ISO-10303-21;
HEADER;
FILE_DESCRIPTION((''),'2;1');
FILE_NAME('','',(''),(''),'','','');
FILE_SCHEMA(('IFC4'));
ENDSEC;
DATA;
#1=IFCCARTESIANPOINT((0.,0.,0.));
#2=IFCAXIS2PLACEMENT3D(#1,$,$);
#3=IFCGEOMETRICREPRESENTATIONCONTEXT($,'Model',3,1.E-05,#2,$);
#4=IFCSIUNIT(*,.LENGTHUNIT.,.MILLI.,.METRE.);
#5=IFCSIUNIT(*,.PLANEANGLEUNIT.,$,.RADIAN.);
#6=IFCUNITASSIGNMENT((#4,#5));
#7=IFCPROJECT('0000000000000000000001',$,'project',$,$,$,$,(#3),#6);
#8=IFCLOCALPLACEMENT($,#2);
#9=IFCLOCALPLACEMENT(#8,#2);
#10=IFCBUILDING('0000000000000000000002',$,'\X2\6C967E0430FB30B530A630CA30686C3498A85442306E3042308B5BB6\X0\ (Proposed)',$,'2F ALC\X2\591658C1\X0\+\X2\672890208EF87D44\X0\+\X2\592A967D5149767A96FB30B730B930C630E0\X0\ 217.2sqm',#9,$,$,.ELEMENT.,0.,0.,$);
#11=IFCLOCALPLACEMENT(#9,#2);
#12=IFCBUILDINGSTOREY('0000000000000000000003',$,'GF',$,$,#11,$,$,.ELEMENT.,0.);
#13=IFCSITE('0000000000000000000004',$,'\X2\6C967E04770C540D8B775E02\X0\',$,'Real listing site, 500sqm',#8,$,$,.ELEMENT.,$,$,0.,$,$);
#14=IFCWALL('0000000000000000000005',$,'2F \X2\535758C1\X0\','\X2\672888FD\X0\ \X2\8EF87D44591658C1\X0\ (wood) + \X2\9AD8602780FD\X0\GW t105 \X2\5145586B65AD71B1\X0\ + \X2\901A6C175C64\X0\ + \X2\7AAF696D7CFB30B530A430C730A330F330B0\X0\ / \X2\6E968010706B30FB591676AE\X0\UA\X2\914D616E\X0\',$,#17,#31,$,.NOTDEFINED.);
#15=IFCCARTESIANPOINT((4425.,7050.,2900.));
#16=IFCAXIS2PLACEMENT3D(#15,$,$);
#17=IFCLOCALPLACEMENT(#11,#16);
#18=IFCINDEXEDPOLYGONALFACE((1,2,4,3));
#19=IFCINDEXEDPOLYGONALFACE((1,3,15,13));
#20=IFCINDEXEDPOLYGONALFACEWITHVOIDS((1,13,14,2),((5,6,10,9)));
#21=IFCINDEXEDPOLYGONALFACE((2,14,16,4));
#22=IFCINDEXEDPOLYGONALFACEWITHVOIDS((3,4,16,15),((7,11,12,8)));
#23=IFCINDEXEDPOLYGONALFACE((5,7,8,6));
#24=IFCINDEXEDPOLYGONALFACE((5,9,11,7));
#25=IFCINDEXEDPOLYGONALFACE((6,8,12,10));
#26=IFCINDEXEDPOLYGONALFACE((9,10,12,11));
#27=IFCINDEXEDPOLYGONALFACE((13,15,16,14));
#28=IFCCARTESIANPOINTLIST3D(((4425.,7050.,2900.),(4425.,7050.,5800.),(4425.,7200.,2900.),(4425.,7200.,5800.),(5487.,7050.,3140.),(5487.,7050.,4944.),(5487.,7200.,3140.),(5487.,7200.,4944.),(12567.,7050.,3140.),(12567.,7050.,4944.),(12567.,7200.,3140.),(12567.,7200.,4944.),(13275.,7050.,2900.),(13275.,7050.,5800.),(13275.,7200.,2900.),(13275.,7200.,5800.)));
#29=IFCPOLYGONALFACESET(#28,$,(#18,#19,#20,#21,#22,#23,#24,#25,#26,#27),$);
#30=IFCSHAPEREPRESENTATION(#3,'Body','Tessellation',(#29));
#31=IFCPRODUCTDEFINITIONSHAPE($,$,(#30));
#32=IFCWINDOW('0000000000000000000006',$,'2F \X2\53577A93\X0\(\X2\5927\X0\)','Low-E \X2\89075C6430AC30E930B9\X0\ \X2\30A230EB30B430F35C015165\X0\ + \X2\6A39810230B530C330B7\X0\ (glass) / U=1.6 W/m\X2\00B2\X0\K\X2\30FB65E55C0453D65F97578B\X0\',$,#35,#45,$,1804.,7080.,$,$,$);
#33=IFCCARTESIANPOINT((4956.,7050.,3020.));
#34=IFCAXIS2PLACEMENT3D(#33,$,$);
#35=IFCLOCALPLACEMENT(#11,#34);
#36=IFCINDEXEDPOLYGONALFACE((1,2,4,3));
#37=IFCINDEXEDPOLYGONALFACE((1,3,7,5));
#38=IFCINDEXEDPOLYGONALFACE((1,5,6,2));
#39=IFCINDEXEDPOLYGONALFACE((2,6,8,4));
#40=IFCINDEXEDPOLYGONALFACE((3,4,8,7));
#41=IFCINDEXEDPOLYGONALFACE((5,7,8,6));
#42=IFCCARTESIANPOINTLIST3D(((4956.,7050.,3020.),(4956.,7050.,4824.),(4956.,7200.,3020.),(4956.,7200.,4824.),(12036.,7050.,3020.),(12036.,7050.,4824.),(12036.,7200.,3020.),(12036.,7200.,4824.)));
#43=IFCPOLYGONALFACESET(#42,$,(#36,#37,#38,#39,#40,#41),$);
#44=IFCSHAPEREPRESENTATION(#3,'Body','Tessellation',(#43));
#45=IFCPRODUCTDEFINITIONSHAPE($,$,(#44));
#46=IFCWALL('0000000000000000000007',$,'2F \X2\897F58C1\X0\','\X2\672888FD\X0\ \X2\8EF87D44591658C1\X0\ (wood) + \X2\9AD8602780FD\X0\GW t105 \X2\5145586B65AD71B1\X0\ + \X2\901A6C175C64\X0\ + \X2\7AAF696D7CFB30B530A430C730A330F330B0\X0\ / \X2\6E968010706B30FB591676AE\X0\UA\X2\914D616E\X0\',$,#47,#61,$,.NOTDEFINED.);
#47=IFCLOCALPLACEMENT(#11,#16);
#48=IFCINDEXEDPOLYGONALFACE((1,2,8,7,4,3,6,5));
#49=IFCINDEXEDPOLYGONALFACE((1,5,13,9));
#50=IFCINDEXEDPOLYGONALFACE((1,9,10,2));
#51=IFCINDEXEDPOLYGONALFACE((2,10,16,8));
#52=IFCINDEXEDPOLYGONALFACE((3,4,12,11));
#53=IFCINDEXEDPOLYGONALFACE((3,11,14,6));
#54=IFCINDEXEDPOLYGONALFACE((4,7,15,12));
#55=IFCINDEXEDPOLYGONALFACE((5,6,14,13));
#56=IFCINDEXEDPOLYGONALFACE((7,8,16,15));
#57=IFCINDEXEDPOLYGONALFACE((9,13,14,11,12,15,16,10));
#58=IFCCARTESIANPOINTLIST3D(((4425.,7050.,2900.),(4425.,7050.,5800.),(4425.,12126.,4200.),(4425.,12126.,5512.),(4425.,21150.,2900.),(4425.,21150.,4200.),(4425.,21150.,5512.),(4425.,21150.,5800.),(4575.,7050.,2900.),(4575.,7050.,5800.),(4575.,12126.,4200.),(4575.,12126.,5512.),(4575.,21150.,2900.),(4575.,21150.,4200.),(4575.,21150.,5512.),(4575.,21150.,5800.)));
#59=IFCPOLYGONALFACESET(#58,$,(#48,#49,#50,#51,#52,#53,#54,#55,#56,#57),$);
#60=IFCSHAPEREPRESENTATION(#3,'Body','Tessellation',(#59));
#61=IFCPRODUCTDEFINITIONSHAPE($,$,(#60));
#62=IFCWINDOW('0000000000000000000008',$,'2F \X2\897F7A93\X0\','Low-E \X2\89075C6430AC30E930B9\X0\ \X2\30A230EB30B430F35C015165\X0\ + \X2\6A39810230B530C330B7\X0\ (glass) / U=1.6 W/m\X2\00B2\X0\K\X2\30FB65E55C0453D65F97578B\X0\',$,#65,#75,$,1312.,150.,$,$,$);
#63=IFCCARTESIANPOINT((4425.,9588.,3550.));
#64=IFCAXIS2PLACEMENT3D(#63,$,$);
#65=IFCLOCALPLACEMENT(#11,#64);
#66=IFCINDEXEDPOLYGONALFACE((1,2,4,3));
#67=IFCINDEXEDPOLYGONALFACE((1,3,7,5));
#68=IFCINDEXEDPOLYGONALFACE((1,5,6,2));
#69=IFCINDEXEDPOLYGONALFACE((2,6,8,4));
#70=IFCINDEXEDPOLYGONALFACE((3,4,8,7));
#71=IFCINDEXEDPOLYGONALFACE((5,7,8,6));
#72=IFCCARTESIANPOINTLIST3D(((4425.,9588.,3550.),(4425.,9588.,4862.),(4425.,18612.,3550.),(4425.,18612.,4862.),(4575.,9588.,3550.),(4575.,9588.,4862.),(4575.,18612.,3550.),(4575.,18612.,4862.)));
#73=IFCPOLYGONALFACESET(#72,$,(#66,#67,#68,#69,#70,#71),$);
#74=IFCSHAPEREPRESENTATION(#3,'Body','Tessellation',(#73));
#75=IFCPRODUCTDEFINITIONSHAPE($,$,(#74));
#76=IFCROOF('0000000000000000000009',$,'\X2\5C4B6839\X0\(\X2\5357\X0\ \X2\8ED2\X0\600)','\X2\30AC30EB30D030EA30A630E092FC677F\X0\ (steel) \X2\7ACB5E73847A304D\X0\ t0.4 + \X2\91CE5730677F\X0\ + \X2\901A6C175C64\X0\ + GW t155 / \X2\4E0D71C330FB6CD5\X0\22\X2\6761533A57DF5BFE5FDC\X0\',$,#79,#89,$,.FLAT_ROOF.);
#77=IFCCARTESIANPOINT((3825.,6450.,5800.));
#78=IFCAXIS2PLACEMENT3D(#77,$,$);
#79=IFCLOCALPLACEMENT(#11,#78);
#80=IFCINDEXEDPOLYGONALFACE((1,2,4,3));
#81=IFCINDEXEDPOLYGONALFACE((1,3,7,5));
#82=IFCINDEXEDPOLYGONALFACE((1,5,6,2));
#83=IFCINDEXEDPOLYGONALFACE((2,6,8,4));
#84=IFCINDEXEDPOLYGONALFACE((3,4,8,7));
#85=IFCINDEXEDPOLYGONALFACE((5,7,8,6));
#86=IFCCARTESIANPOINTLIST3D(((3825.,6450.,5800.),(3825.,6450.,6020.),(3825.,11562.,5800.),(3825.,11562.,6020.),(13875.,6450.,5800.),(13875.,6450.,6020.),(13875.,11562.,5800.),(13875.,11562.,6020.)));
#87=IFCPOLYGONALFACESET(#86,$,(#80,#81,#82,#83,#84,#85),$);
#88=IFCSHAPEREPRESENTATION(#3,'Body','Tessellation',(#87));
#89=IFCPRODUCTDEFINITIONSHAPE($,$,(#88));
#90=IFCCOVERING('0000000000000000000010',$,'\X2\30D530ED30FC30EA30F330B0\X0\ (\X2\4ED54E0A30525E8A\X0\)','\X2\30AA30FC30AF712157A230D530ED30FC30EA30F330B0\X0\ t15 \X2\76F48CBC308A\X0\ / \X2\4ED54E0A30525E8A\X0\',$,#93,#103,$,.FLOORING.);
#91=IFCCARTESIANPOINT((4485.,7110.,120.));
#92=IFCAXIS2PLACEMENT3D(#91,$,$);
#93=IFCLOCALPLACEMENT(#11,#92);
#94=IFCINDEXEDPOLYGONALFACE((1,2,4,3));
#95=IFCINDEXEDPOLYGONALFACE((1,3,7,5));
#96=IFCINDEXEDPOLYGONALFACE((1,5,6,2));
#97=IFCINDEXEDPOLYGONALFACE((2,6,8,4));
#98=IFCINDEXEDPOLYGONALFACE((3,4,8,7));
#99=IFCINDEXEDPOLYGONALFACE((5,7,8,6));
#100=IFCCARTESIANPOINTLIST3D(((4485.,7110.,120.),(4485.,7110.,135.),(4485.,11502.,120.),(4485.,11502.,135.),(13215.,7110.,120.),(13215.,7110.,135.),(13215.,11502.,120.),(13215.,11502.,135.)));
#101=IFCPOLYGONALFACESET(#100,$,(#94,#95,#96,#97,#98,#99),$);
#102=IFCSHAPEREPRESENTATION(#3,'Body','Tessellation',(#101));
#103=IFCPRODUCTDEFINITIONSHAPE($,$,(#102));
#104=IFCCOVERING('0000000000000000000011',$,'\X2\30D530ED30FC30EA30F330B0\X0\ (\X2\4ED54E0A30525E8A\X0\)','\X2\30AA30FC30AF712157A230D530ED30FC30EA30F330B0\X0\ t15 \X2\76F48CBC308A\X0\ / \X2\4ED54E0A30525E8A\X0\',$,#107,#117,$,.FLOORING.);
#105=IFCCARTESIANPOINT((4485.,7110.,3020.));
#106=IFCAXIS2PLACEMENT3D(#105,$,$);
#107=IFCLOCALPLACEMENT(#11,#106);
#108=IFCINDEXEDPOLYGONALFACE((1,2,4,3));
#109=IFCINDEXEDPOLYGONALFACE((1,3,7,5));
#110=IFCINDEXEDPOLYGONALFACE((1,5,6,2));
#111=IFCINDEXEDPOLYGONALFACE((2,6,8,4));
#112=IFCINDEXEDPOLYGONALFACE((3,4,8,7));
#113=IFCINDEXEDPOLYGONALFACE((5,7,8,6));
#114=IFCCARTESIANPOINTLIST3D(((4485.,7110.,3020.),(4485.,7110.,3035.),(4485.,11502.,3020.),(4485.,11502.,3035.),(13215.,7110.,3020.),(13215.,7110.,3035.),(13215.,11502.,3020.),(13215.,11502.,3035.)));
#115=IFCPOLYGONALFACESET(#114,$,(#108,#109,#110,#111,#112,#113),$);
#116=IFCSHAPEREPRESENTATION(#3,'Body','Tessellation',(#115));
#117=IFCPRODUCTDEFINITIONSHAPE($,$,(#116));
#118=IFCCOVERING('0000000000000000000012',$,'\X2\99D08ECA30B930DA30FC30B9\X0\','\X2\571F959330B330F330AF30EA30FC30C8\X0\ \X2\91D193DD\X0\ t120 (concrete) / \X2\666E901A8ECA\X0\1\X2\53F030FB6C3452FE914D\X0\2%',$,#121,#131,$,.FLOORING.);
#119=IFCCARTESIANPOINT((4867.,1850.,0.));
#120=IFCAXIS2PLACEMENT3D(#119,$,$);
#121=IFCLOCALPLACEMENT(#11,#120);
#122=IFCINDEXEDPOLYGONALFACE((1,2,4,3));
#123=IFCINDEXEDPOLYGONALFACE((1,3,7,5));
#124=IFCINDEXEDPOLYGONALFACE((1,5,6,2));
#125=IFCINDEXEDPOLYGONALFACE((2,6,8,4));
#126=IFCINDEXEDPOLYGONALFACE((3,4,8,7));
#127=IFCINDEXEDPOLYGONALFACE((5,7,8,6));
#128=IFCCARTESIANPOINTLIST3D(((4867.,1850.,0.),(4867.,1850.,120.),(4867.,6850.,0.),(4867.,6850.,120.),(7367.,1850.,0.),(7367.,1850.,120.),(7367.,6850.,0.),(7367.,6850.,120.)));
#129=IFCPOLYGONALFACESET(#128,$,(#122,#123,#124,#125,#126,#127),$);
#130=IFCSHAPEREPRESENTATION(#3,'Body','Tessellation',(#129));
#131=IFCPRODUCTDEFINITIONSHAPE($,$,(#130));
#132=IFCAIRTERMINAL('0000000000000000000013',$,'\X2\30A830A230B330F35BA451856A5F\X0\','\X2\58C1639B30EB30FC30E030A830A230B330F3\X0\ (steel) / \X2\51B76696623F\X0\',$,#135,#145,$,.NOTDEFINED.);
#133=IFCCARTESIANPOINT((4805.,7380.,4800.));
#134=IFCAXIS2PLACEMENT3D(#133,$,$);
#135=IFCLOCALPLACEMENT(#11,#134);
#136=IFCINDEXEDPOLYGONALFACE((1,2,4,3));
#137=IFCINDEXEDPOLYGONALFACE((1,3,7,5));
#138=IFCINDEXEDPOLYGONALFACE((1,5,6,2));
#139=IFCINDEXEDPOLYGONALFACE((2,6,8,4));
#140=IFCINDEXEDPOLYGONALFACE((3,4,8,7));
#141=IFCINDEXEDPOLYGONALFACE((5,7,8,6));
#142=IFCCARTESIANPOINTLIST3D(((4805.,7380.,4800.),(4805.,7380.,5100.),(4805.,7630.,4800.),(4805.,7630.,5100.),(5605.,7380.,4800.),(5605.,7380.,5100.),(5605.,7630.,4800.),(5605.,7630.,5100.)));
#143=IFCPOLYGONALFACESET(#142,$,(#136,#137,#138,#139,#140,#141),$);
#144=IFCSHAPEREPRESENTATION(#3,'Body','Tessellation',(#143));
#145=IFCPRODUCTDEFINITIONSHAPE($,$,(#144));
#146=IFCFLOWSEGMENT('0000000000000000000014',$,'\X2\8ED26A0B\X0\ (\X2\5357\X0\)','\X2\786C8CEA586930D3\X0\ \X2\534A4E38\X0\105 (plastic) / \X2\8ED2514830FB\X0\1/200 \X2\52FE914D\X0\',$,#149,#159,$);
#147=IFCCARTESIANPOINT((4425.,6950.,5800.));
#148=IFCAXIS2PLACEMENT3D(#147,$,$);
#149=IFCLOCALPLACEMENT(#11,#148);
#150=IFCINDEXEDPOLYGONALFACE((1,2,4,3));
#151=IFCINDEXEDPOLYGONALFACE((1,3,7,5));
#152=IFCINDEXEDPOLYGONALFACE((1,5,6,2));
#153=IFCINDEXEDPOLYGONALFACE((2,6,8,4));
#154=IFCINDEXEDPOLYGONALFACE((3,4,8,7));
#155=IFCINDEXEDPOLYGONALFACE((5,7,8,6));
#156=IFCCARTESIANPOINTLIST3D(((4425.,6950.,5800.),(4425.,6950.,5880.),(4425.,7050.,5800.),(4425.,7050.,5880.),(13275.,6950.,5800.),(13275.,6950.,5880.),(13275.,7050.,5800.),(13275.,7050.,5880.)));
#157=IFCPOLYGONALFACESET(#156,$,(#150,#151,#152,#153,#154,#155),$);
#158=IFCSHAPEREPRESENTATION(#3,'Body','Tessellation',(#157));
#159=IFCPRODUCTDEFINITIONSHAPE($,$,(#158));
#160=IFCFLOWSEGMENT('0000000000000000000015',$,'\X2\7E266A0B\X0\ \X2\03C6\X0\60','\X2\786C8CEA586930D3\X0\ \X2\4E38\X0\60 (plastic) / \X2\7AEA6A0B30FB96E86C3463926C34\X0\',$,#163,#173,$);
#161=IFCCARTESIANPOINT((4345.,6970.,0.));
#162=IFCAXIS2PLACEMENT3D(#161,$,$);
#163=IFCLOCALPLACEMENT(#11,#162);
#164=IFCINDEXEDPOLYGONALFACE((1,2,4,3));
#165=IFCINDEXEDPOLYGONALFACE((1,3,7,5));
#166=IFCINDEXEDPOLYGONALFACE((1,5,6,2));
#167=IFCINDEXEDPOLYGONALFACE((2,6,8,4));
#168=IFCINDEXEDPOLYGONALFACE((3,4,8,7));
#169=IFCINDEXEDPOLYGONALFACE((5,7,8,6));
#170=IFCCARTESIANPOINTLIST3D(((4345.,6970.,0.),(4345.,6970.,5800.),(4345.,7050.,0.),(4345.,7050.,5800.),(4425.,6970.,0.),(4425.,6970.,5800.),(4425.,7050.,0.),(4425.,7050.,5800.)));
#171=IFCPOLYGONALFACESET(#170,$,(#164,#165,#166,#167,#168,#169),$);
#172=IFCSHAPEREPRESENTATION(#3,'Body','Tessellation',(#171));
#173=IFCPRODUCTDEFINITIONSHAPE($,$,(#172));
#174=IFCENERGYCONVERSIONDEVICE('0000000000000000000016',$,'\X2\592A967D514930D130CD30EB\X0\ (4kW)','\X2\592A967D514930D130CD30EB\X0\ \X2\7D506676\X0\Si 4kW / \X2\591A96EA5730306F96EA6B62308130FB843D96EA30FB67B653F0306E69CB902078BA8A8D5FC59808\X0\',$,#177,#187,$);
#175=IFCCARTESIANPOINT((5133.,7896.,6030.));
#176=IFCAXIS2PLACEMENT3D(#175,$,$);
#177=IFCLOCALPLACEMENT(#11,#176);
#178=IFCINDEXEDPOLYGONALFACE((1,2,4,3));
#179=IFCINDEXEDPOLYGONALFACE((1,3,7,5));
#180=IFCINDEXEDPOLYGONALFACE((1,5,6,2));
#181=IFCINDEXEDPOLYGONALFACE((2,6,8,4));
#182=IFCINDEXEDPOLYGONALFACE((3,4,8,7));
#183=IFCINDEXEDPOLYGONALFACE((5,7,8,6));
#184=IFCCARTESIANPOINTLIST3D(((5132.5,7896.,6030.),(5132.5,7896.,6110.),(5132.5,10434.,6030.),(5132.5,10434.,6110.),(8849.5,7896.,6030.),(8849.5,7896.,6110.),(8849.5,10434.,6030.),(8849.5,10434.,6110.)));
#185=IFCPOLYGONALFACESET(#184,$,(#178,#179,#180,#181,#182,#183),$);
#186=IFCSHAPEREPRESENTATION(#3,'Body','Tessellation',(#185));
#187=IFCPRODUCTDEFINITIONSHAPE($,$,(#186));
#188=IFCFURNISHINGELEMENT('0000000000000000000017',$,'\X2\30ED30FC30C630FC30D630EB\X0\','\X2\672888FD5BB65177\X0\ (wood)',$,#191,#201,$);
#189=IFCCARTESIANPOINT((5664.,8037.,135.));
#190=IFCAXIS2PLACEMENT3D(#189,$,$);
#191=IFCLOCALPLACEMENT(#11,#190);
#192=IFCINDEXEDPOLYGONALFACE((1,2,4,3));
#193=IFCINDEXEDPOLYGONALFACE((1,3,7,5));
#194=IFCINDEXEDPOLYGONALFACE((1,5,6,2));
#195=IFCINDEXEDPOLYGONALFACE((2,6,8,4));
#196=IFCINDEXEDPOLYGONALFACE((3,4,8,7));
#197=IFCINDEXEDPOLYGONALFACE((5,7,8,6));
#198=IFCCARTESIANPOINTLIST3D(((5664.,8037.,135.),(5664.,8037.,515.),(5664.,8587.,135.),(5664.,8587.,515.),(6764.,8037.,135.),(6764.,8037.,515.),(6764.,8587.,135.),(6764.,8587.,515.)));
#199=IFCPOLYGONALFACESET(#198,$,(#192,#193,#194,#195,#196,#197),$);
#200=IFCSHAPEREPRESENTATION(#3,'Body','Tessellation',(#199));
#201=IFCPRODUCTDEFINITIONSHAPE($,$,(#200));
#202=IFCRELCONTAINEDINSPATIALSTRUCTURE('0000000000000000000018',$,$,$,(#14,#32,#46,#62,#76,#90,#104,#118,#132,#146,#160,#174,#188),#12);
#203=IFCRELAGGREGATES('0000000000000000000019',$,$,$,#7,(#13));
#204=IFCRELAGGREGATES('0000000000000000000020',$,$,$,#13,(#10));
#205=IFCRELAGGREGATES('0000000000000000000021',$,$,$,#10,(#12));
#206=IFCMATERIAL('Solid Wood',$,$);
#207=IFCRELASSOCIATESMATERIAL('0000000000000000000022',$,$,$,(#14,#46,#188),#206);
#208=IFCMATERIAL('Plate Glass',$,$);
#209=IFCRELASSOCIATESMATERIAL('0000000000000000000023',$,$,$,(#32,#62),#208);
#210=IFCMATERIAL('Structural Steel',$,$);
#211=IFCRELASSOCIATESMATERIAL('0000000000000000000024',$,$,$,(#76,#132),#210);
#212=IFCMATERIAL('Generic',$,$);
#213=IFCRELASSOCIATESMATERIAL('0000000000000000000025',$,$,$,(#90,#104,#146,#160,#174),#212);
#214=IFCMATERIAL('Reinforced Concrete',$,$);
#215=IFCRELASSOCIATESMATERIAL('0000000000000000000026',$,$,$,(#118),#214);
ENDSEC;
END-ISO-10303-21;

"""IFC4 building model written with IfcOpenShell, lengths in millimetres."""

from ifc_helpers import new_model, si_unit, frame, frame_2d, origin, place, context, project, spatial, rectangle, extrude, material, element, fill, save


model = new_model("IFC4")

# Units and contexts
model_context = context("Model", 3, precision=1e-05, world=origin())
ifc_project = project(units=[si_unit("LENGTHUNIT", "METRE", prefix="MILLI"), si_unit("PLANEANGLEUNIT", "RADIAN")], contexts=[model_context])

# Site, building, storey
site_placement = place(None, origin())
site = spatial("IfcSite", under=ifc_project, at=site_placement, Name="沖縄県名護市", ObjectType="Real listing site, 500sqm", CompositionType="ELEMENT", RefElevation=0.0)
building_placement = place(site_placement, origin())
building = spatial("IfcBuilding", under=site, at=building_placement, Name="沖縄・サウナと水風呂のある家 (Proposed)", ObjectType="2F ALC外壁+木造軸組+太陽光発電システム 217.2sqm", CompositionType="ELEMENT", ElevationOfRefHeight=0.0, ElevationOfTerrain=0.0)
storey_placement = place(building_placement, origin())
storey = spatial("IfcBuildingStorey", under=building, at=storey_placement, Name="GF", CompositionType="ELEMENT", Elevation=0.0)

# Shared definitions
ifc_material_1 = material(Name="Solid Wood")

# Shared definitions
ifc_material_2 = material(Name="Reinforced Concrete")

# Shared definitions
ifc_material_3 = material(Name="Plate Glass")

# Walls, openings, windows
wall_1_placement = place(storey_placement, frame((4425.0, 7050.0, 2900.0)))
wall_1 = element("IfcWall", 1, at=wall_1_placement, inside=storey, material=ifc_material_1, Name="2F 南壁", Description="木製 軸組外壁 (wood) + 高性能GW t105 充填断熱 + 通気層 + 窯業系サイディング / 準耐火・外皮UA配慮", PredefinedType="NOTDEFINED", context=model_context, shape_type="SweptSolid", body=[
    extrude(rectangle(XDim=8850.0, YDim=150.0, at=frame_2d((4425.0, 75.0))), frame((4425.0, 7050.0, 2900.0)), (0.0, 0.0, 1.0), 2900.0),
])
opening_1_placement = place(storey_placement, frame((4956.0, 7050.0, 3020.0)))
opening_1 = element("IfcOpeningElement", 2, at=opening_1_placement, cuts=wall_1, PredefinedType="NOTDEFINED", context=model_context, shape_type="SweptSolid", body=[
    extrude(rectangle(XDim=7080.0, YDim=150.0, at=frame_2d((3540.0, 75.0))), frame((4956.0, 7050.0, 3020.0)), (0.0, 0.0, 1.0), 1804.0),
])
window_1_placement = place(storey_placement, frame((4956.0, 7050.0, 3020.0)))
window_1 = element("IfcWindow", 3, at=window_1_placement, inside=storey, material=ifc_material_3, Name="2F 南窓(大)", Description="Low-E 複層ガラス アルゴン封入 + 樹脂サッシ (glass) / U=1.6 W/m²K・日射取得型", OverallHeight=1804.0, OverallWidth=7080.0, context=model_context, shape_type="SweptSolid", body=[
    extrude(rectangle(XDim=7080.0, YDim=150.0, at=frame_2d((3540.0, 75.0))), frame((4956.0, 7050.0, 3020.0)), (0.0, 0.0, 1.0), 1804.0),
])
fill(opening_1, window_1)
wall_2_placement = place(storey_placement, frame((4425.0, 7050.0, 2900.0)))
wall_2 = element("IfcWall", 4, at=wall_2_placement, inside=storey, material=ifc_material_1, Name="2F 西壁", Description="木製 軸組外壁 (wood) + 高性能GW t105 充填断熱 + 通気層 + 窯業系サイディング / 準耐火・外皮UA配慮", PredefinedType="NOTDEFINED", context=model_context, shape_type="SweptSolid", body=[
    extrude(rectangle(XDim=150.0, YDim=14100.0, at=frame_2d((75.0, 7050.0))), frame((4425.0, 7050.0, 2900.0)), (0.0, 0.0, 1.0), 2900.0),
])
opening_2_placement = place(storey_placement, frame((4425.0, 9588.0, 3550.0)))
opening_2 = element("IfcOpeningElement", 5, at=opening_2_placement, cuts=wall_2, PredefinedType="NOTDEFINED", context=model_context, shape_type="SweptSolid", body=[
    extrude(rectangle(XDim=150.0, YDim=9024.0, at=frame_2d((75.0, 4512.0))), frame((4425.0, 9588.0, 3550.0)), (0.0, 0.0, 1.0), 1312.0),
])
window_2_placement = place(storey_placement, frame((4425.0, 9588.0, 3550.0)))
window_2 = element("IfcWindow", 6, at=window_2_placement, inside=storey, material=ifc_material_3, Name="2F 西窓", Description="Low-E 複層ガラス アルゴン封入 + 樹脂サッシ (glass) / U=1.6 W/m²K・日射取得型", OverallHeight=1312.0, OverallWidth=150.0, context=model_context, shape_type="SweptSolid", body=[
    extrude(rectangle(XDim=150.0, YDim=9024.0, at=frame_2d((75.0, 4512.0))), frame((4425.0, 9588.0, 3550.0)), (0.0, 0.0, 1.0), 1312.0),
])
fill(opening_2, window_2)

# Roof
ifc_material_4 = material(Name="Structural Steel")
for number, where, name in (
    (7, (3825.0, 6450.0, 5800.0), "屋根(南 軒600)"),
):
    element("IfcRoof", number, at=place(storey_placement, frame(where)), inside=storey, material=ifc_material_4, Name=name, Description="ガルバリウム鋼板 (steel) 立平葺き t0.4 + 野地板 + 通気層 + GW t155 / 不燃・法22条区域対応", PredefinedType="FLAT_ROOF", context=model_context, shape_type="SweptSolid", body=[
        extrude(rectangle(XDim=10050.0, YDim=5112.0, at=frame_2d((5025.0, 2556.0))), frame((3825.0, 6450.0, 5800.0)), (0.0, 0.0, 1.0), 220.0),
    ])

# Coverings
ifc_material_5 = material(Name="Generic")
covering_1_placement = place(storey_placement, frame((4485.0, 7110.0, 120.0)))
element("IfcCovering", 8, at=covering_1_placement, inside=storey, material=ifc_material_5, Name="フローリング (仕上げ床)", Description="オーク無垢フローリング t15 直貼り / 仕上げ床", PredefinedType="FLOORING", context=model_context, shape_type="SweptSolid", body=[
    extrude(rectangle(XDim=8730.0, YDim=4392.0, at=frame_2d((4365.0, 2196.0))), frame((4485.0, 7110.0, 120.0)), (0.0, 0.0, 1.0), 15.0),
])
covering_2_placement = place(storey_placement, frame((4485.0, 7110.0, 3020.0)))
element("IfcCovering", 9, at=covering_2_placement, inside=storey, material=ifc_material_5, Name="フローリング (仕上げ床)", Description="オーク無垢フローリング t15 直貼り / 仕上げ床", PredefinedType="FLOORING", context=model_context, shape_type="SweptSolid", body=[
    extrude(rectangle(XDim=8730.0, YDim=4392.0, at=frame_2d((4365.0, 2196.0))), frame((4485.0, 7110.0, 3020.0)), (0.0, 0.0, 1.0), 15.0),
])
covering_3_placement = place(storey_placement, frame((4867.0, 1850.0, 0.0)))
element("IfcCovering", 10, at=covering_3_placement, inside=storey, material=ifc_material_2, Name="駐車スペース", Description="土間コンクリート 金鏝 t120 (concrete) / 普通車1台・水勾配2%", PredefinedType="FLOORING", context=model_context, shape_type="SweptSolid", body=[
    extrude(rectangle(XDim=2500.0, YDim=5000.0, at=frame_2d((1250.0, 2500.0))), frame((4867.0, 1850.0, 0.0)), (0.0, 0.0, 1.0), 120.0),
])

# Air terminal
air_terminal_placement = place(storey_placement, frame((4805.0, 7380.0, 4800.0)))
element("IfcAirTerminal", 11, at=air_terminal_placement, inside=storey, material=ifc_material_4, Name="エアコン室内機", Description="壁掛ルームエアコン (steel) / 冷暖房", PredefinedType="NOTDEFINED", context=model_context, shape_type="SweptSolid", body=[
    extrude(rectangle(XDim=800.0, YDim=250.0, at=frame_2d((400.0, 125.0))), frame((4805.0, 7380.0, 4800.0)), (0.0, 0.0, 1.0), 300.0),
])

# Flow segments
flow_segment_1_placement = place(storey_placement, frame((4425.0, 6950.0, 5800.0)))
element("IfcFlowSegment", 12, at=flow_segment_1_placement, inside=storey, material=ifc_material_5, Name="軒樋 (南)", Description="硬質塩ビ 半丸105 (plastic) / 軒先・1/200 勾配", context=model_context, shape_type="SweptSolid", body=[
    extrude(rectangle(XDim=8850.0, YDim=100.0, at=frame_2d((4425.0, 50.0))), frame((4425.0, 6950.0, 5800.0)), (0.0, 0.0, 1.0), 80.0),
])
flow_segment_2_placement = place(storey_placement, frame((4345.0, 6970.0, 0.0)))
element("IfcFlowSegment", 13, at=flow_segment_2_placement, inside=storey, material=ifc_material_5, Name="縦樋 φ60", Description="硬質塩ビ 丸60 (plastic) / 竪樋・雨水排水", context=model_context, shape_type="SweptSolid", body=[
    extrude(rectangle(XDim=80.0, YDim=80.0, at=frame_2d((40.0, 40.0))), frame((4345.0, 6970.0, 0.0)), (0.0, 0.0, 1.0), 5800.0),
])

# Energy conversion device
energy_conversion_device_placement = place(storey_placement, frame((5133.0, 7896.0, 6030.0)))
element("IfcEnergyConversionDevice", 14, at=energy_conversion_device_placement, inside=storey, material=ifc_material_5, Name="太陽光パネル (4kW)", Description="太陽光パネル 結晶Si 4kW / 多雪地は雪止め・落雪・架台の構造確認必須", context=model_context, shape_type="SweptSolid", body=[
    extrude(rectangle(XDim=3717.0, YDim=2538.0, at=frame_2d((1858.0, 1269.0))), frame((5133.0, 7896.0, 6030.0)), (0.0, 0.0, 1.0), 80.0),
])

# Furnishing element
furnishing_1_placement = place(storey_placement, frame((5664.0, 8037.0, 135.0)))
element("IfcFurnishingElement", 15, at=furnishing_1_placement, inside=storey, material=ifc_material_1, Name="ローテーブル", Description="木製家具 (wood)", context=model_context, shape_type="SweptSolid", body=[
    extrude(rectangle(XDim=1100.0, YDim=550.0, at=frame_2d((550.0, 275.0))), frame((5664.0, 8037.0, 135.0)), (0.0, 0.0, 1.0), 380.0),
])

save(model, "model.ifc")
